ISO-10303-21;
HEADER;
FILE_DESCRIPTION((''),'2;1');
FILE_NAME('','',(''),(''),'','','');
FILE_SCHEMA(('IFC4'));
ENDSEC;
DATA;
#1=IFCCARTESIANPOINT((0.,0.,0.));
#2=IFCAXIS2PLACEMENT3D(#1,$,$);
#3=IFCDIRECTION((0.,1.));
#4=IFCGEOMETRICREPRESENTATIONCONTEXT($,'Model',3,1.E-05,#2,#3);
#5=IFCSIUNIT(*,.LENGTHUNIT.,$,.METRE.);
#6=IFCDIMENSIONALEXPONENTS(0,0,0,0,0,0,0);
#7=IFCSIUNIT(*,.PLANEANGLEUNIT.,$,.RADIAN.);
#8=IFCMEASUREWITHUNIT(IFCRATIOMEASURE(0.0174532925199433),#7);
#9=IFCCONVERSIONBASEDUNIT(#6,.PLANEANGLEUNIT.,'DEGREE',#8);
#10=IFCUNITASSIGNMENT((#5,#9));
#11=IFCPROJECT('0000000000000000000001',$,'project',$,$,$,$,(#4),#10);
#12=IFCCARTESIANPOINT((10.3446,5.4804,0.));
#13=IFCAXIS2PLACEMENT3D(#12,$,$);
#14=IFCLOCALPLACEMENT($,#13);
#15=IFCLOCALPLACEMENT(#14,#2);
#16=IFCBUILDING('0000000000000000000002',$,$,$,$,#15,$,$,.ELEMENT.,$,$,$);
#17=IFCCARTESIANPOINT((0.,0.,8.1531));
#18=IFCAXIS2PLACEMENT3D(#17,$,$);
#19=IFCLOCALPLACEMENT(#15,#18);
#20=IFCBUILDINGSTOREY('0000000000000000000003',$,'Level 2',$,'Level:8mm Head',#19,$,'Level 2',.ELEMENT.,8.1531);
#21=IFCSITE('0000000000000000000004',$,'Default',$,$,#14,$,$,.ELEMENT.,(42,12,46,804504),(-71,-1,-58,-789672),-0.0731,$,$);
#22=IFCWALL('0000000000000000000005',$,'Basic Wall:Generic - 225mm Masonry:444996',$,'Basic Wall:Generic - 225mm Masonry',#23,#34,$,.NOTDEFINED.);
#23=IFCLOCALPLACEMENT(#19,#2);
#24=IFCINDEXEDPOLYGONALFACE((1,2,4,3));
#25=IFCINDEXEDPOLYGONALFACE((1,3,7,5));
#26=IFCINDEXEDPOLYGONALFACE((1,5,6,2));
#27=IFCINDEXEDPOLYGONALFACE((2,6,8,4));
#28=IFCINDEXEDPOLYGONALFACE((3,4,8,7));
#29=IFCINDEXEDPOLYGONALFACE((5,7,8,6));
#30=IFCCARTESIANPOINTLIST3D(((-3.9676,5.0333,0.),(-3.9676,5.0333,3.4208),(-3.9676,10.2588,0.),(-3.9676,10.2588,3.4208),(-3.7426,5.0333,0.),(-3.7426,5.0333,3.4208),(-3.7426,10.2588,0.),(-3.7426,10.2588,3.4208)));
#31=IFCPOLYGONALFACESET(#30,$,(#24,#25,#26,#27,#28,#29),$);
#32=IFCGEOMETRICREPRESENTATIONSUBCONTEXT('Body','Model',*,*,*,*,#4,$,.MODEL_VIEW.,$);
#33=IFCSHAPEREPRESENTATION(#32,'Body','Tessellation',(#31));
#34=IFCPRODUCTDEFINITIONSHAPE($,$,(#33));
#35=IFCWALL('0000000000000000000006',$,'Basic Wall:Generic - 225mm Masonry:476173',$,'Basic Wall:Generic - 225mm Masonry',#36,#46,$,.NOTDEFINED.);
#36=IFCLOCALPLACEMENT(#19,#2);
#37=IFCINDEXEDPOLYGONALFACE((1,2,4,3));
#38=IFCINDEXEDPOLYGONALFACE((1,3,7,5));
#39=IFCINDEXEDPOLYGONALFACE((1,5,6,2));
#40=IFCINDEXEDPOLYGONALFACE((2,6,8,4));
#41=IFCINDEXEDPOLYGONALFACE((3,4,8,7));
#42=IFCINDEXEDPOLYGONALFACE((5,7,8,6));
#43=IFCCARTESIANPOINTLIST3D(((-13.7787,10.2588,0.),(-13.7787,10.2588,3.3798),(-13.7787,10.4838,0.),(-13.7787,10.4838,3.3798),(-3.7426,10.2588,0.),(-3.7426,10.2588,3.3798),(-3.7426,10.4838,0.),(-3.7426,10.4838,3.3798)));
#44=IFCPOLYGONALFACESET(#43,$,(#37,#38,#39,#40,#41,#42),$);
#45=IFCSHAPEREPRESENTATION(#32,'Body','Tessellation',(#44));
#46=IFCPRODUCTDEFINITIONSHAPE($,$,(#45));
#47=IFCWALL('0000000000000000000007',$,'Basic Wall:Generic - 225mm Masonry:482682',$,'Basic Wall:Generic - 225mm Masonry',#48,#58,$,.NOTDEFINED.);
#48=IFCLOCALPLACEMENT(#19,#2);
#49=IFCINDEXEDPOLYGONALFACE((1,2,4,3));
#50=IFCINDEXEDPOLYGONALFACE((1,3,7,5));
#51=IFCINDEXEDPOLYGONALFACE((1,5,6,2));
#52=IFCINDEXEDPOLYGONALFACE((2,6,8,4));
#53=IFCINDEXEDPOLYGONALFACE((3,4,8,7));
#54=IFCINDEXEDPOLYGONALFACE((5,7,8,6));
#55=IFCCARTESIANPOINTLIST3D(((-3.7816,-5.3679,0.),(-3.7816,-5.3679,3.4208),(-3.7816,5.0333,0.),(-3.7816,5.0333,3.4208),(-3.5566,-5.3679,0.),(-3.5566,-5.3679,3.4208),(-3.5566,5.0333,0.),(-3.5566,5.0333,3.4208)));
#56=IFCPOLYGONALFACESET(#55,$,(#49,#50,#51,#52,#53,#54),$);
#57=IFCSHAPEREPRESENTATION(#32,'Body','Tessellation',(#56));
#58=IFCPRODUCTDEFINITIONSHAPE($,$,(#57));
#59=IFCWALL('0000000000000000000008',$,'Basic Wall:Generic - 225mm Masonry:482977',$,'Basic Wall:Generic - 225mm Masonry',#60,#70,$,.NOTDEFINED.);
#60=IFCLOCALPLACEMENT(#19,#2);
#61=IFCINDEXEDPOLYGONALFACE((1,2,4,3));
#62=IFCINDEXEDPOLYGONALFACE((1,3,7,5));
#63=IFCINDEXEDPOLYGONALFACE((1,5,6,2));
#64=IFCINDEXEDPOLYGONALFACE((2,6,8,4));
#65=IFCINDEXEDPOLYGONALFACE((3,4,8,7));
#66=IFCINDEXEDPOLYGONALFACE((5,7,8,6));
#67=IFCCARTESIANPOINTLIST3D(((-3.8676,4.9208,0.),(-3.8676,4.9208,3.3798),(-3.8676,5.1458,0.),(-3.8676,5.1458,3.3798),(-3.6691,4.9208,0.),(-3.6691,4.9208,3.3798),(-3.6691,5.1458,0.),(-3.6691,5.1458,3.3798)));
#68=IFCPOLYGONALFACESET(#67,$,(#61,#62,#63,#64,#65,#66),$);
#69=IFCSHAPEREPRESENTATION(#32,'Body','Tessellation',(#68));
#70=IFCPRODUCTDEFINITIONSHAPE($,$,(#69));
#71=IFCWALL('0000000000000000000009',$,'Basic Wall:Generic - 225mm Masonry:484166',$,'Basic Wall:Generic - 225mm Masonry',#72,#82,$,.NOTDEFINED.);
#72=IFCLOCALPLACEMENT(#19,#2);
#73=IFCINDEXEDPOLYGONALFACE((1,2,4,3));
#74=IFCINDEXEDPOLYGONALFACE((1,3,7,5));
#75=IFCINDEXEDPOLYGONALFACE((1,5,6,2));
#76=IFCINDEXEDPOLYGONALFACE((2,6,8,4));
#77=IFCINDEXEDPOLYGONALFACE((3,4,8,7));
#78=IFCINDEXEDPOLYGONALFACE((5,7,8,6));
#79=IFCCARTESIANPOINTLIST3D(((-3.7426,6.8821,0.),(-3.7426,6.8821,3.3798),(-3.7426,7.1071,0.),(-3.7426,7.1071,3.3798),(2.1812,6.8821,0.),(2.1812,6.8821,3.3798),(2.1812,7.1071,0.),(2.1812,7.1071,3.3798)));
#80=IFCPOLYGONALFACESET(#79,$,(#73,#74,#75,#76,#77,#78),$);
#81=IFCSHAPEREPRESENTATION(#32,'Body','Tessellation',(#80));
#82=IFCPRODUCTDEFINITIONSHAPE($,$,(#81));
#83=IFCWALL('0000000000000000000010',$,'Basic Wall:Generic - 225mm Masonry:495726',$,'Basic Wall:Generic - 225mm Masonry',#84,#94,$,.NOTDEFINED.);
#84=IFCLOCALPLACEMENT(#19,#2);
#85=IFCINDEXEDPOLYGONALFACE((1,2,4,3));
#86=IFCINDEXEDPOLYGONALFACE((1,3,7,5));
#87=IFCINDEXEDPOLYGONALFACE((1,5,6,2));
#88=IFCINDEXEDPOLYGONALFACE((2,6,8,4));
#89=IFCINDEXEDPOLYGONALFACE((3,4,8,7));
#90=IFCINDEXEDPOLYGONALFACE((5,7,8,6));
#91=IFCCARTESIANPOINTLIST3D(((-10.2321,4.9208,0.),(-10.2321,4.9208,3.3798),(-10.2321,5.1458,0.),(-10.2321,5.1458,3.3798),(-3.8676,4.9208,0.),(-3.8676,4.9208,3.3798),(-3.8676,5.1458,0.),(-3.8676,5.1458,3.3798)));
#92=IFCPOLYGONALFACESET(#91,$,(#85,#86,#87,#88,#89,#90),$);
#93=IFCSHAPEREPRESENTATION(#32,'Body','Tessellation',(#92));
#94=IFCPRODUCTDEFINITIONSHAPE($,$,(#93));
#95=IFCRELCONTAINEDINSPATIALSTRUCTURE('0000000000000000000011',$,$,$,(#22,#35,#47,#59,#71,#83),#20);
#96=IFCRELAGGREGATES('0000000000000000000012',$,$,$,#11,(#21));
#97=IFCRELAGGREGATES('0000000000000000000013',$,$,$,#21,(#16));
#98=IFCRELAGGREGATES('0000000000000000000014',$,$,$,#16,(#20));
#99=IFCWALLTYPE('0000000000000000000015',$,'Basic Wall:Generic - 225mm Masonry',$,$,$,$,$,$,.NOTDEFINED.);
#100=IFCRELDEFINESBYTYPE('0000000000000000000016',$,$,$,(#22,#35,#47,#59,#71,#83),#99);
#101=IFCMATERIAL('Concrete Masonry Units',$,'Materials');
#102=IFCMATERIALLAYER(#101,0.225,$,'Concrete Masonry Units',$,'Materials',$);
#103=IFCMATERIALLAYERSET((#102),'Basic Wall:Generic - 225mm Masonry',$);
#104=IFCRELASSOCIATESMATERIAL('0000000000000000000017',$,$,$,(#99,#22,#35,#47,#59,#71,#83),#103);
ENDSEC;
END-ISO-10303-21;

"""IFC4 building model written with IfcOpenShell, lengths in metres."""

from ifc_helpers import new_model, entity, si_unit, converted_unit, direction, frame, frame_2d, origin, place, context, subcontext, project, spatial, polyline, rectangle, extrude, clip, bounded_halfspace, material, layer, layer_set, layer_usage, type_object, element, save


model = new_model("IFC4")

# Units and contexts
model_context = context("Model", 3, precision=1e-05, world=origin(), true_north=direction((0.0, 1.0)))
body_context = subcontext(model_context, "Body", "Model", "MODEL_VIEW")
ifc_project = project(units=[si_unit("LENGTHUNIT", "METRE"), converted_unit("PLANEANGLEUNIT", "DEGREE", entity("IfcRatioMeasure", 0.0174532925199433), si_unit("PLANEANGLEUNIT", "RADIAN"), dimensions=[0, 0, 0, 0, 0, 0, 0])], contexts=[model_context])

# Site, building, storey
site_placement = place(None, frame((10.3446, 5.4804, 0.0)))
site = spatial("IfcSite", under=ifc_project, at=site_placement, Name="Default", CompositionType="ELEMENT", RefLatitude=(42, 12, 46, 804504), RefLongitude=(-71, -1, -58, -789672), RefElevation=-0.0731)
building_placement = place(site_placement, origin())
building = spatial("IfcBuilding", under=site, at=building_placement, CompositionType="ELEMENT")
storey_placement = place(building_placement, frame((0.0, 0.0, 8.1531)))
storey = spatial("IfcBuildingStorey", under=building, at=storey_placement, Name="Level 2", ObjectType="Level:8mm Head", LongName="Level 2", CompositionType="ELEMENT", Elevation=8.1531)

# Walls
ifc_material_1 = material(Name="Concrete Masonry Units", Category="Materials")
ifc_layer = layer(ifc_material_1, 0.225, Name="Concrete Masonry Units", Category="Materials")
ifc_layer_set = layer_set([ifc_layer], Name="Basic Wall:Generic - 225mm Masonry")
wall_type = type_object("IfcWallType", Name="Basic Wall:Generic - 225mm Masonry", PredefinedType="NOTDEFINED", material=ifc_layer_set)
ifc_layer_usage_1 = layer_usage(ifc_layer_set, "AXIS2", "NEGATIVE", 0.1125)
wall_1_placement = place(storey_placement, frame((-3.8551, 10.2588, 0.0), z_axis=(0.0, 0.0, 1.0), x_axis=(0.0, -1.0, 0.0)))
element("IfcWall", 1, at=wall_1_placement, inside=storey, type_object=wall_type, material=ifc_layer_usage_1, Name="Basic Wall:Generic - 225mm Masonry:444996", ObjectType="Basic Wall:Generic - 225mm Masonry", PredefinedType="NOTDEFINED", context=body_context, shape_type="SweptSolid", body=[
    extrude(rectangle(XDim=5.2255, YDim=0.225, at=frame_2d((2.6127, 0.0), x_axis=(-1.0, 0.0))), origin(), (0.0, 0.0, 1.0), 3.4208),
])
ifc_layer_usage_2 = layer_usage(ifc_layer_set, "AXIS2", "NEGATIVE", 0.1125)
wall_2_placement = place(storey_placement, frame((-3.7426, 10.3713, 0.0), z_axis=(0.0, 0.0, 1.0), x_axis=(-1.0, 0.0, 0.0)))
element("IfcWall", 2, at=wall_2_placement, inside=storey, type_object=wall_type, material=ifc_layer_usage_2, Name="Basic Wall:Generic - 225mm Masonry:476173", ObjectType="Basic Wall:Generic - 225mm Masonry", PredefinedType="NOTDEFINED", context=body_context, shape_type="Clipping", body=[
    clip(extrude(rectangle(XDim=10.0361, YDim=0.225, at=frame_2d((5.018, 0.0), x_axis=(-1.0, 0.0))), origin(), (0.0, 0.0, 1.0), 3.3798), bounded_halfspace(frame((9.9236, 0.0, 3.3798), z_axis=(0.0, 0.0, -1.0), x_axis=(0.0, 1.0, 0.0)), True, frame((9.9236, 0.0, 3.3798)), polyline([(0.0, 0.0), (0.0, 0.1125), (-0.1125, 0.1125), (-9.8111, 0.1125), (-9.8111, 0.0), (0.0, 0.0)]))),
])
ifc_layer_usage_3 = layer_usage(ifc_layer_set, "AXIS2", "NEGATIVE", 0.1125)
wall_3_placement = place(storey_placement, frame((-3.6691, -5.3679, 0.0), z_axis=(0.0, 0.0, 1.0), x_axis=(0.0, 1.0, 0.0)))
element("IfcWall", 3, at=wall_3_placement, inside=storey, type_object=wall_type, material=ifc_layer_usage_3, Name="Basic Wall:Generic - 225mm Masonry:482682", ObjectType="Basic Wall:Generic - 225mm Masonry", PredefinedType="NOTDEFINED", context=body_context, shape_type="SweptSolid", body=[
    extrude(rectangle(XDim=10.4013, YDim=0.225, at=frame_2d((5.2006, 0.0), x_axis=(-1.0, 0.0))), origin(), (0.0, 0.0, 1.0), 3.4208),
])
ifc_layer_usage_4 = layer_usage(ifc_layer_set, "AXIS2", "NEGATIVE", 0.1125)
wall_4_placement = place(storey_placement, frame((-3.6691, 5.0333, 0.0), z_axis=(0.0, 0.0, 1.0), x_axis=(-1.0, 0.0, 0.0)))
element("IfcWall", 4, at=wall_4_placement, inside=storey, type_object=wall_type, material=ifc_layer_usage_4, Name="Basic Wall:Generic - 225mm Masonry:482977", ObjectType="Basic Wall:Generic - 225mm Masonry", PredefinedType="NOTDEFINED", context=body_context, shape_type="Clipping", body=[
    clip(clip(extrude(rectangle(XDim=0.1985, YDim=0.225, at=frame_2d((0.0993, 0.0), x_axis=(-1.0, 0.0))), origin(), (0.0, 0.0, 1.0), 3.3798), bounded_halfspace(frame((0.186, -0.1125, 3.3798), z_axis=(0.0, 0.0, -1.0), x_axis=(0.0, 1.0, 0.0)), True, frame((0.186, -0.1125, 3.3798)), polyline([(0.0, 0.0), (0.0125, 0.0), (0.0125, 0.225), (0.0, 0.225), (0.0, 0.0)]))), bounded_halfspace(frame((0.0, -0.1125, 3.3798), z_axis=(0.0, 0.0, -1.0), x_axis=(0.0, 1.0, 0.0)), True, frame((0.0, -0.1125, 3.3798)), polyline([(0.0, 0.0), (0.186, 0.0), (0.186, 0.225), (0.0, 0.225), (0.0, 0.0)]))),
])
ifc_layer_usage_5 = layer_usage(ifc_layer_set, "AXIS2", "NEGATIVE", 0.1125)
wall_5_placement = place(storey_placement, frame((-3.7426, 6.9946, 0.0)))
element("IfcWall", 5, at=wall_5_placement, inside=storey, type_object=wall_type, material=ifc_layer_usage_5, Name="Basic Wall:Generic - 225mm Masonry:484166", ObjectType="Basic Wall:Generic - 225mm Masonry", PredefinedType="NOTDEFINED", context=body_context, shape_type="Clipping", body=[
    clip(extrude(rectangle(XDim=5.9238, YDim=0.225, at=frame_2d((2.9619, 0.0), x_axis=(-1.0, 0.0))), origin(), (0.0, 0.0, 1.0), 3.3798), bounded_halfspace(frame((0.0, -0.1125, 3.3798), z_axis=(0.0, 0.0, -1.0), x_axis=(0.0, -1.0, 0.0)), True, frame((0.0, -0.1125, 3.3798)), polyline([(0.0, 0.0), (5.9238, 0.0), (5.9238, 0.1125), (0.0, 0.1125), (0.0, 0.0)]))),
])
ifc_layer_usage_6 = layer_usage(ifc_layer_set, "AXIS2", "NEGATIVE", 0.1125)
wall_6_placement = place(storey_placement, frame((-3.8676, 5.0333, 0.0), z_axis=(0.0, 0.0, 1.0), x_axis=(-1.0, 0.0, 0.0)))
element("IfcWall", 6, at=wall_6_placement, inside=storey, type_object=wall_type, material=ifc_layer_usage_6, Name="Basic Wall:Generic - 225mm Masonry:495726", ObjectType="Basic Wall:Generic - 225mm Masonry", PredefinedType="NOTDEFINED", context=body_context, shape_type="Clipping", body=[
    clip(extrude(rectangle(XDim=6.3645, YDim=0.225, at=frame_2d((3.1823, 0.0), x_axis=(-1.0, 0.0))), origin(), (0.0, 0.0, 1.0), 3.3798), bounded_halfspace(frame((0.0, -0.1125, 3.3798), z_axis=(0.0, 0.0, -1.0), x_axis=(0.0, 1.0, 0.0)), True, frame((0.0, -0.1125, 3.3798)), polyline([(0.0, 0.0), (6.3645, 0.0), (6.3645, 0.2014), (6.3645, 0.225), (0.0, 0.225), (0.0, 0.0)]))),
])

save(model, "model.ifc")
